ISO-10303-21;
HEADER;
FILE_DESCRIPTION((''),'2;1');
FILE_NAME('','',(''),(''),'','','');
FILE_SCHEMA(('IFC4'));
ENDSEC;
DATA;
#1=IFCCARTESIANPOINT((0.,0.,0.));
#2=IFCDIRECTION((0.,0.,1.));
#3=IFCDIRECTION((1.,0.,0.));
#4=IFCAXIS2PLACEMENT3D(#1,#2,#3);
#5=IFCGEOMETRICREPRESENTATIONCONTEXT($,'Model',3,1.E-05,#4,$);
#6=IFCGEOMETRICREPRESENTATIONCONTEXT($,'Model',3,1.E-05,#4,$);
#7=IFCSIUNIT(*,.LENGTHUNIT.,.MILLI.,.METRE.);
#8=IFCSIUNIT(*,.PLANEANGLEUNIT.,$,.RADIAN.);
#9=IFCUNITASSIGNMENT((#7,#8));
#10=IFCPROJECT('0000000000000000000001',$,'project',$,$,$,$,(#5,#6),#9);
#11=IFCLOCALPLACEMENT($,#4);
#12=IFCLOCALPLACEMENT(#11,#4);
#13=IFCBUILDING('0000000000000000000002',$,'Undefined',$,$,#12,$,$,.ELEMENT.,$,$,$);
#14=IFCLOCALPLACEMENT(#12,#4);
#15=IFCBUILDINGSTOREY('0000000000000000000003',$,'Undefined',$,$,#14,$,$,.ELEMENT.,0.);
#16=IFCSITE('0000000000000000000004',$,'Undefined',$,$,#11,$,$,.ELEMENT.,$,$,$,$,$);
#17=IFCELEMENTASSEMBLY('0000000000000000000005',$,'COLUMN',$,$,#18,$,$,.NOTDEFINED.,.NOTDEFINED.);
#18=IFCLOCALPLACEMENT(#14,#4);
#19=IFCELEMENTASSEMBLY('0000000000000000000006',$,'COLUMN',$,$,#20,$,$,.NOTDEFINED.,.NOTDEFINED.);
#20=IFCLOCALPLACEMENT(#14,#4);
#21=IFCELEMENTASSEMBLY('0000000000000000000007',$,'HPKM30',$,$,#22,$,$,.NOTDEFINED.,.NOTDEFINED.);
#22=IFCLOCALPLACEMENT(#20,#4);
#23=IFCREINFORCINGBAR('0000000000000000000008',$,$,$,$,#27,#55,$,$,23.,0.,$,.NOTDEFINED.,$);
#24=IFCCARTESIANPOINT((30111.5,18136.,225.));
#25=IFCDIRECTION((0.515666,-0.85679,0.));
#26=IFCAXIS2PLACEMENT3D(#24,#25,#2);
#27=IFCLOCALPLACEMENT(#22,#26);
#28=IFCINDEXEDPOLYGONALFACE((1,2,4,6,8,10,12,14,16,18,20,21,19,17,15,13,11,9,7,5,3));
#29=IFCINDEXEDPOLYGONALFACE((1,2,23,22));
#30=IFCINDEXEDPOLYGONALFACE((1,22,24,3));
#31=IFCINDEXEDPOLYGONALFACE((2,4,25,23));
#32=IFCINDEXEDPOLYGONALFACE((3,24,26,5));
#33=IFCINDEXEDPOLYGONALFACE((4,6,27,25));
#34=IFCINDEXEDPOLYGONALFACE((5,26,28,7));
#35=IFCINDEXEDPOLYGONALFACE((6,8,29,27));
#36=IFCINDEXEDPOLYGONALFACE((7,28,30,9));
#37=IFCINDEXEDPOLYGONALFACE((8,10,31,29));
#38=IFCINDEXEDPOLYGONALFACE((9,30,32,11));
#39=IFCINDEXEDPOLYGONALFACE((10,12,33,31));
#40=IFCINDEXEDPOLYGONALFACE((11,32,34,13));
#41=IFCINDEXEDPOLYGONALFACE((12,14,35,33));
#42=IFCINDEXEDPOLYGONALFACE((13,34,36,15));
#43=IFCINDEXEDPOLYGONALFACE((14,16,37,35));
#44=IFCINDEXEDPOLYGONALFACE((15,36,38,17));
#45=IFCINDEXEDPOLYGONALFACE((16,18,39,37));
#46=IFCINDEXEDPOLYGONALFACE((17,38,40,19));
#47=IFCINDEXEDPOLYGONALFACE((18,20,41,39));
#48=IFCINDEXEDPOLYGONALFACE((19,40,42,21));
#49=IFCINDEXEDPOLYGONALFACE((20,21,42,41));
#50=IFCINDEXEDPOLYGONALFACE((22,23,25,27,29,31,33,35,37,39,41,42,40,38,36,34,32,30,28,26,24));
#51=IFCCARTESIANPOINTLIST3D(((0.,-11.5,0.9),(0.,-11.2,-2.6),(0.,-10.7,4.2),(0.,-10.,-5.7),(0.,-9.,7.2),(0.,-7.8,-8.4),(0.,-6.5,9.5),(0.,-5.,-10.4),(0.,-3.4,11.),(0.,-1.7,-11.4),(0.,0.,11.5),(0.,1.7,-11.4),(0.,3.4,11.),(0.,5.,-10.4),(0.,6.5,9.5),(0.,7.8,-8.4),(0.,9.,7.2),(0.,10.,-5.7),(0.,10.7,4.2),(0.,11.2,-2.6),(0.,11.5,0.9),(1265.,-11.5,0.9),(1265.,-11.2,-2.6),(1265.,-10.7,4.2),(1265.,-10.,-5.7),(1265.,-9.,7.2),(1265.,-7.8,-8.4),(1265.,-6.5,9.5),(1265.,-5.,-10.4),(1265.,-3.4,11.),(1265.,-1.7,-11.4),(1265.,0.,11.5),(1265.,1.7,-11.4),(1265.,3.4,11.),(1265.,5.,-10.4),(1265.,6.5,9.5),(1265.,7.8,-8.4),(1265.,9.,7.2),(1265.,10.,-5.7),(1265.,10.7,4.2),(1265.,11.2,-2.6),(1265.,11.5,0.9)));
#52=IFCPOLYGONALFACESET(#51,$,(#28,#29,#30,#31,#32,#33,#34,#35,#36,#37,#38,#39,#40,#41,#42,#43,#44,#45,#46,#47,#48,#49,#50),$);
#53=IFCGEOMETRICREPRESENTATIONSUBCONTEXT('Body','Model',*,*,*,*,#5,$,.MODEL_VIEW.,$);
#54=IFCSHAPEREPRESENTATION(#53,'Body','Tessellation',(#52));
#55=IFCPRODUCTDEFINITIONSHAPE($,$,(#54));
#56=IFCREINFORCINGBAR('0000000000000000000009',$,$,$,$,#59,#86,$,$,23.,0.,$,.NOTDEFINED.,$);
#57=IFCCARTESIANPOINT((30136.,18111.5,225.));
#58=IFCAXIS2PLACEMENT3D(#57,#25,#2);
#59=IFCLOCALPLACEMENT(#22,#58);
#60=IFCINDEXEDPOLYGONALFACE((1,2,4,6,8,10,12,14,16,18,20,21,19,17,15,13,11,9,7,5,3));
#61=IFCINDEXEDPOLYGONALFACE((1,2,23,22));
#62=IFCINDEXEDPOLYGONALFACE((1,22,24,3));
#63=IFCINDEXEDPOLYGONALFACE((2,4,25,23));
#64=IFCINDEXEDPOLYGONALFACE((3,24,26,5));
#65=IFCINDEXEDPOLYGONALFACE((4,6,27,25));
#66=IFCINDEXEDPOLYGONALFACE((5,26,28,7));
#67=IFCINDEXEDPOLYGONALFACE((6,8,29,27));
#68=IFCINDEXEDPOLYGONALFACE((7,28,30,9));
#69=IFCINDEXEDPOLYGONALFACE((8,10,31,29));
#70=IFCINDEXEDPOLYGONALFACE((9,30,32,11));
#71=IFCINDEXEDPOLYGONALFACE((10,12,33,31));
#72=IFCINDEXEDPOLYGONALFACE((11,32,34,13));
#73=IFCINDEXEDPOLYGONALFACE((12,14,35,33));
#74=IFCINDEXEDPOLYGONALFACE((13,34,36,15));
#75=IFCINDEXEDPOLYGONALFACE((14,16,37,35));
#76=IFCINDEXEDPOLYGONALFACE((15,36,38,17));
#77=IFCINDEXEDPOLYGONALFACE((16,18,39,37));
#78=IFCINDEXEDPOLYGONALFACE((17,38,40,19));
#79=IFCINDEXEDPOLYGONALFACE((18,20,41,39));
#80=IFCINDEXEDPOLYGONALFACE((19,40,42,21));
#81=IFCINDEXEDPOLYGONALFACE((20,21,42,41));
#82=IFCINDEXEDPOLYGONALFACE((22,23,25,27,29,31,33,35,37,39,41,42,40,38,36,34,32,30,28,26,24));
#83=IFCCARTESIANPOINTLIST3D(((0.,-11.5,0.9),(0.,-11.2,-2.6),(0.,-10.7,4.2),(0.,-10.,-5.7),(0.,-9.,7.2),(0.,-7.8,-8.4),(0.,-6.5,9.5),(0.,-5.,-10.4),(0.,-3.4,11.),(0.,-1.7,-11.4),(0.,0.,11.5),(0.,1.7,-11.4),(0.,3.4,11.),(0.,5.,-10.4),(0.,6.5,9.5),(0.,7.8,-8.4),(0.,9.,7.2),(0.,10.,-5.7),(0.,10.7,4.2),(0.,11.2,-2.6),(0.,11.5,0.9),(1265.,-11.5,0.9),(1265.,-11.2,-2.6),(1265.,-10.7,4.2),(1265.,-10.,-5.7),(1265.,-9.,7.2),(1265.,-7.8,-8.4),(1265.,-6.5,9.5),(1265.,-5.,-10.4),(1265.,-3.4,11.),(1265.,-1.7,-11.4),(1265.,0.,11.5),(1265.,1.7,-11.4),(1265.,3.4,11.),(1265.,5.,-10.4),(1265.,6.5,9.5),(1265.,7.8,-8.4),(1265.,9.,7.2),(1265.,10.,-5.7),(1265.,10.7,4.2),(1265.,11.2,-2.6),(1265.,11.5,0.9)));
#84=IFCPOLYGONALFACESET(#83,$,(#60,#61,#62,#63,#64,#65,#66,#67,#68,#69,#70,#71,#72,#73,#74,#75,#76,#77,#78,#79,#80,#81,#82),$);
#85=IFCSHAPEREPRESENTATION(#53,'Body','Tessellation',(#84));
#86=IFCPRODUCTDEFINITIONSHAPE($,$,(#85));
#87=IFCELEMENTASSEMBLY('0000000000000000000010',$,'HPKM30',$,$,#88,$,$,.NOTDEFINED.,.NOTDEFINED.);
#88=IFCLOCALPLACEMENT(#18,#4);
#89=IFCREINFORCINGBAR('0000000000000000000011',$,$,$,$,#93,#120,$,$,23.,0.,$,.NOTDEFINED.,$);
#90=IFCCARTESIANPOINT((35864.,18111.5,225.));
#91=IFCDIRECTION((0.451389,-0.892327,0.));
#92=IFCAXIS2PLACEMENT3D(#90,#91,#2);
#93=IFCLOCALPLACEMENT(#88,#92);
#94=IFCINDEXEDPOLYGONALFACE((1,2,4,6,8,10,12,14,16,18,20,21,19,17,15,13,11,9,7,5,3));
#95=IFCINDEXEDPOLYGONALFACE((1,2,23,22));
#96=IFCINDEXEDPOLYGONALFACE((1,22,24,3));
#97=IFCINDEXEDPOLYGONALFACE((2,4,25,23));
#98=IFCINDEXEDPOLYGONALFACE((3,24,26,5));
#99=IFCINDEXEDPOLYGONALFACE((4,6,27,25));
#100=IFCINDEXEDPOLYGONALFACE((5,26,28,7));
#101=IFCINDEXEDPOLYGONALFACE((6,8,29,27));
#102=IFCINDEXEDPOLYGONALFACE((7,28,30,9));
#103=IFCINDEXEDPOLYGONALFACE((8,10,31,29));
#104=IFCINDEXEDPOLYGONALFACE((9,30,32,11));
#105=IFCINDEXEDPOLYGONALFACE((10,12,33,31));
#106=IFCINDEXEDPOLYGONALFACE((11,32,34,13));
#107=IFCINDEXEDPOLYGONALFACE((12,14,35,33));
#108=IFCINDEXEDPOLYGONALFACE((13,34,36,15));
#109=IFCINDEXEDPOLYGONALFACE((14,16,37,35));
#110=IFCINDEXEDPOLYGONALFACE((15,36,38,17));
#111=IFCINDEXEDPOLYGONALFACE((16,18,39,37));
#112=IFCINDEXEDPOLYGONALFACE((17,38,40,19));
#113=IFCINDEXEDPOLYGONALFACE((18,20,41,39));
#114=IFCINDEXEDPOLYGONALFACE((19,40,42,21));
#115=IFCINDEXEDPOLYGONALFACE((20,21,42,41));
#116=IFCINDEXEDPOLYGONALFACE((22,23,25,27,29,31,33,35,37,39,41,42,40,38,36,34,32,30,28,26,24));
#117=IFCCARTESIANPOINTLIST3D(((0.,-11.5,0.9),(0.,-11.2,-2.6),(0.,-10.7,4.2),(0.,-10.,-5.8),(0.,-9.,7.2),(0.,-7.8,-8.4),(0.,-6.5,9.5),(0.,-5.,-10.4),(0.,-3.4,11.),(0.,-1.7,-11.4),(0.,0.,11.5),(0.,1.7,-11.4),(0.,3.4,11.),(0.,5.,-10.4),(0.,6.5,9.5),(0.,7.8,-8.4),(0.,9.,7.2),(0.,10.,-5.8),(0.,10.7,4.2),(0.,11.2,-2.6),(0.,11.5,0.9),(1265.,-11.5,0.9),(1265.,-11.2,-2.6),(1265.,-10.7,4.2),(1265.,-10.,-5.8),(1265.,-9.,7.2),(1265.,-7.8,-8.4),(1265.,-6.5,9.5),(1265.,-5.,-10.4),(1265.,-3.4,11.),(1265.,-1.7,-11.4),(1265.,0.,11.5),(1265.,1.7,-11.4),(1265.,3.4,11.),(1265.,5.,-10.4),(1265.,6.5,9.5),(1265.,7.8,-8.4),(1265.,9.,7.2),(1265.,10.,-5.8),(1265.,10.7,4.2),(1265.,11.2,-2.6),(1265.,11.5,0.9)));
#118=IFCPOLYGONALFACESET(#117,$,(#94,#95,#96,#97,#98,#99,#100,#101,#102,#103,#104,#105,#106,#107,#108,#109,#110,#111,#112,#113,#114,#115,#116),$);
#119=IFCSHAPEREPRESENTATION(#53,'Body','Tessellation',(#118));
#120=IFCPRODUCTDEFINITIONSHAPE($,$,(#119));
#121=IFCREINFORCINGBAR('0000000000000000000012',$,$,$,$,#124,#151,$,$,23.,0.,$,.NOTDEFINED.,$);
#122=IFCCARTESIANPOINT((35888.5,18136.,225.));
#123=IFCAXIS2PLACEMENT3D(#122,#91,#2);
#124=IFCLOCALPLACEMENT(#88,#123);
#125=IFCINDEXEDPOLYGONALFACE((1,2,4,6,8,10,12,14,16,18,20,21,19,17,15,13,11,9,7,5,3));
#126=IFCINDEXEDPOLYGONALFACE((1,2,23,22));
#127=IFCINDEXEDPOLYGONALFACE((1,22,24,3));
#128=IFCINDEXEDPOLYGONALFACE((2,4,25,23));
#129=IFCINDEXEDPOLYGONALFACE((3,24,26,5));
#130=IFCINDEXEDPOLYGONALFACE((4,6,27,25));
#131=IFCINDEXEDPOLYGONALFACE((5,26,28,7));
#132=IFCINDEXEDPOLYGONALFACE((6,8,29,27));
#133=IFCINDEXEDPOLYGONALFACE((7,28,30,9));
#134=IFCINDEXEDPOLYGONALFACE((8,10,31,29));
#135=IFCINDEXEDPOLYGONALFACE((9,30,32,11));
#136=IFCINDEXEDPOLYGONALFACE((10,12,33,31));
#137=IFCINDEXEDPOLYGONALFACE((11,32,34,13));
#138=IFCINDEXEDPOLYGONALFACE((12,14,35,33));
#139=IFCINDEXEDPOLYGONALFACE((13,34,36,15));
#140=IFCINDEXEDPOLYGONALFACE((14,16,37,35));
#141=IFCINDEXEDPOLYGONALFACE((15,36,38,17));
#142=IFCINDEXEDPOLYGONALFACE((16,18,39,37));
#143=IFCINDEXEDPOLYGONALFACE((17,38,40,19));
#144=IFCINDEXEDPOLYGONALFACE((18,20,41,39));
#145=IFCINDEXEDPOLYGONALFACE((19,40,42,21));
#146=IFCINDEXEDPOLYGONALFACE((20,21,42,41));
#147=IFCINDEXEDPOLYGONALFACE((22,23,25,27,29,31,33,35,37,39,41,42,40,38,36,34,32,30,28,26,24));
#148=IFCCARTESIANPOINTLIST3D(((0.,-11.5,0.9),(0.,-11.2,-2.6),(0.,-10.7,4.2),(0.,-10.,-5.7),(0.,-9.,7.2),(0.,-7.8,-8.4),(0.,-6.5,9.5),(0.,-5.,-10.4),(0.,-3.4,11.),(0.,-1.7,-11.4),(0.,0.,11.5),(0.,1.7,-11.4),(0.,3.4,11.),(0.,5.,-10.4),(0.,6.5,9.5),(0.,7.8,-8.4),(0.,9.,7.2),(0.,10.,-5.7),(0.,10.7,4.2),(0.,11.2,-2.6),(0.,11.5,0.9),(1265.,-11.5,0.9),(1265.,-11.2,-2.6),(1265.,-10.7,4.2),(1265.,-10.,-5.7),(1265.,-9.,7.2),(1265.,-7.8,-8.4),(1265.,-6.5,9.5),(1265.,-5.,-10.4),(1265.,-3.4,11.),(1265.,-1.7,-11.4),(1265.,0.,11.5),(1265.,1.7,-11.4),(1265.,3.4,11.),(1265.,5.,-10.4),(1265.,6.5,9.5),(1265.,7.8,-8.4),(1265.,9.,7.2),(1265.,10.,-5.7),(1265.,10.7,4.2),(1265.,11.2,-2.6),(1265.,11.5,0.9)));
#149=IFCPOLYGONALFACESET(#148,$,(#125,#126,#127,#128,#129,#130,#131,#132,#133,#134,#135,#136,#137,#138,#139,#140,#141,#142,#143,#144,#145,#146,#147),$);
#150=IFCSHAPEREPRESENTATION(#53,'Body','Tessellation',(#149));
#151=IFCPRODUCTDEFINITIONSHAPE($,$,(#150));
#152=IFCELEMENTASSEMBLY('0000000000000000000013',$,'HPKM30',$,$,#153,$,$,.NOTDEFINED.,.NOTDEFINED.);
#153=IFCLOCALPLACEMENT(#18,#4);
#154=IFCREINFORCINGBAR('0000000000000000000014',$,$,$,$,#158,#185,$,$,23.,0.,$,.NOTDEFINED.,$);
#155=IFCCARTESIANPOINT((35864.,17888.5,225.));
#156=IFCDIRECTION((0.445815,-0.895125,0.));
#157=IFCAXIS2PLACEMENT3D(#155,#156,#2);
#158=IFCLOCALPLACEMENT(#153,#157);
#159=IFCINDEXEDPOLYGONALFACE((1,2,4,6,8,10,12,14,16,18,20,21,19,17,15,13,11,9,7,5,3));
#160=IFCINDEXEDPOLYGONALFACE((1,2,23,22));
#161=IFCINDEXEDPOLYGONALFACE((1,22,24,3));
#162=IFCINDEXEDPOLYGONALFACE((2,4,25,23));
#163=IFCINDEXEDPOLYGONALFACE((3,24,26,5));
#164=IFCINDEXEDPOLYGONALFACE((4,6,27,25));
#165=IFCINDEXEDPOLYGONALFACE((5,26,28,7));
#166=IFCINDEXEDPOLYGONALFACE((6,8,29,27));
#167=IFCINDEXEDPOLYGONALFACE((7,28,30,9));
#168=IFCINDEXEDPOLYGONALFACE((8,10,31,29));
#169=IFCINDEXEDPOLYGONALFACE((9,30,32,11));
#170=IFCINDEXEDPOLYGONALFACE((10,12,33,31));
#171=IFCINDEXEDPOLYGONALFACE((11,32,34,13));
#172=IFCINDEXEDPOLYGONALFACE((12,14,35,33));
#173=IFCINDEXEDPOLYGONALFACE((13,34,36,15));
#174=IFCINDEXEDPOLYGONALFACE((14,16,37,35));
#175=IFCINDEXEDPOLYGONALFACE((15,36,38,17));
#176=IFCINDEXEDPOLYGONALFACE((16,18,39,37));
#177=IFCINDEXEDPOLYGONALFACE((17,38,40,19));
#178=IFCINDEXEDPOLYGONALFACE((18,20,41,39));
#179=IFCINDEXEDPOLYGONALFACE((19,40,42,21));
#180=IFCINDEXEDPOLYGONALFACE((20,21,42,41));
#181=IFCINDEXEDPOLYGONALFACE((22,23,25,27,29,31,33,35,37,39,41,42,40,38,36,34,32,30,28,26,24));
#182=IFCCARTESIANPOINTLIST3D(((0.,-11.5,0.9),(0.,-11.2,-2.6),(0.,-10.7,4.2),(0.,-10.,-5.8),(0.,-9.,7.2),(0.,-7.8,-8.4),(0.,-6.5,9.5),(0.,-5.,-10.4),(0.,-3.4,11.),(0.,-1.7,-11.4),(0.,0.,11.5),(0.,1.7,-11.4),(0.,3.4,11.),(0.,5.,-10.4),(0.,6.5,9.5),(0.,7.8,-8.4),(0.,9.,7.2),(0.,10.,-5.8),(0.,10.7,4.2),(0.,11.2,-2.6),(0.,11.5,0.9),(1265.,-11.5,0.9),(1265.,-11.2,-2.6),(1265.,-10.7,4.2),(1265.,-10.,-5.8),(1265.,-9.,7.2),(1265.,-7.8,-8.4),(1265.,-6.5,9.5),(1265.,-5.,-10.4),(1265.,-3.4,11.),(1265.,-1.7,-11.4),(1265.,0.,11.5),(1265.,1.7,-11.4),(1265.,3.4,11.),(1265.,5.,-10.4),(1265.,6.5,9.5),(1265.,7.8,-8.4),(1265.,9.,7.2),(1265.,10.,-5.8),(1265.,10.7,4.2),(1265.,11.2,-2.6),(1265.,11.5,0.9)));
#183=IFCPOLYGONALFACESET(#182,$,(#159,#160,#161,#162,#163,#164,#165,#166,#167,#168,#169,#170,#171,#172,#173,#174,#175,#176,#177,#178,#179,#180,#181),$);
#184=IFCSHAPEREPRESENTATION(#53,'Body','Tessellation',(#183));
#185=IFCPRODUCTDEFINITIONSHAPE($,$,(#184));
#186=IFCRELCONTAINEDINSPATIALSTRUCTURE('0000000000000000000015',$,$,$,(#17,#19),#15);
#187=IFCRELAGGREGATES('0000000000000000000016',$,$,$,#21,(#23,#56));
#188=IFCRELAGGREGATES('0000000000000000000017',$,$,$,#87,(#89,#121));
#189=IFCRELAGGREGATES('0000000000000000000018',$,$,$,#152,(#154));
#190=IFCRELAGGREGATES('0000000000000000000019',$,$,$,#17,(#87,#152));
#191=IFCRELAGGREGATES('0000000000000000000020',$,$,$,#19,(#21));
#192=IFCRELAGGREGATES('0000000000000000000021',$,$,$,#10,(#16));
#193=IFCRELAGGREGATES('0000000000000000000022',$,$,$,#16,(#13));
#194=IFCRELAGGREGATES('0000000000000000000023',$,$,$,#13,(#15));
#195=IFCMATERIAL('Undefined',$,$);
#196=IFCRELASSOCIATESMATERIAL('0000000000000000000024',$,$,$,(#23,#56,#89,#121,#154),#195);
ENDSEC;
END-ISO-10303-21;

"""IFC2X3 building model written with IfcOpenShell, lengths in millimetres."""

from ifc_helpers import new_model, entity, si_unit, frame, origin_with_axes, place, context, subcontext, project, spatial, source, transform, mapped, material, element, aggregate, save


model = new_model("IFC2X3")

# Units and contexts
model_context_1 = context("Model", 3, precision=1e-05, world=origin_with_axes())
model_context_2 = context("Model", 3, precision=1e-05, world=origin_with_axes())
body_context = subcontext(model_context_1, "Body", "Model", "MODEL_VIEW")
ifc_project = project(units=[si_unit("LENGTHUNIT", "METRE", prefix="MILLI"), si_unit("PLANEANGLEUNIT", "RADIAN")], contexts=[model_context_1, model_context_2])

# Site, building, storey
site_placement = place(None, origin_with_axes())
site = spatial("IfcSite", under=ifc_project, at=site_placement, Name="Undefined", CompositionType="ELEMENT")
building_placement = place(site_placement, origin_with_axes())
building = spatial("IfcBuilding", under=site, at=building_placement, Name="Undefined", CompositionType="ELEMENT")
storey_placement = place(building_placement, origin_with_axes())
storey = spatial("IfcBuildingStorey", under=building, at=storey_placement, Name="Undefined", CompositionType="ELEMENT", Elevation=0.0)

# Element assembly
assembly_1_placement = place(storey_placement, origin_with_axes())
assembly_1 = element("IfcElementAssembly", 1, at=assembly_1_placement, inside=storey, Name="COLUMN", AssemblyPlace="NOTDEFINED", PredefinedType="NOTDEFINED")

# Shared definitions
ifc_material_1 = material(Name="Undefined")

# Element assembly
assembly_2_placement = place(storey_placement, origin_with_axes())
assembly_2 = element("IfcElementAssembly", 2, at=assembly_2_placement, inside=storey, Name="COLUMN", AssemblyPlace="NOTDEFINED", PredefinedType="NOTDEFINED")

# Element assemblies, reinforcing bars
assembly_3_placement = place(assembly_2_placement, origin_with_axes())
assembly_3 = element("IfcElementAssembly", 3, at=assembly_3_placement, Name="HPKM30", AssemblyPlace="NOTDEFINED", PredefinedType="NOTDEFINED")
shared_shape_1 = source(origin_with_axes(), body_context, "Body", "AdvancedSweptSolid", [
    entity("IfcSweptDiskSolid", entity("IfcTrimmedCurve", entity("IfcLine", entity("IfcCartesianPoint", [0.0, 0.0, 0.0]), entity("IfcVector", entity("IfcDirection", [1.0, 0.0, 0.0]), 1.0)), [entity("IfcParameterValue", 0.0)], [entity("IfcParameterValue", 1265.0)], True, "PARAMETER"), 11.5, None, 0.0, 1265.0),
])
reinforcing_bar_1_placement = place(assembly_3_placement, frame((30111.5, 18136.0, 225.0), z_axis=(0.515666, -0.85679, 0.0), x_axis=(0.0, 0.0, 1.0)))
reinforcing_bar_1 = element("IfcReinforcingBar", 4, at=reinforcing_bar_1_placement, material=ifc_material_1, BarRole="NOTDEFINED", CrossSectionArea=0.0, NominalDiameter=23.0, context=body_context, shape_type="MappedRepresentation", body=[
    mapped(shared_shape_1, transform((0.0, 0.0, 0.0))),
])
shared_shape_2 = source(origin_with_axes(), body_context, "Body", "AdvancedSweptSolid", [
    entity("IfcSweptDiskSolid", entity("IfcTrimmedCurve", entity("IfcLine", entity("IfcCartesianPoint", [0.0, 0.0, 0.0]), entity("IfcVector", entity("IfcDirection", [1.0, 0.0, 0.0]), 1.0)), [entity("IfcParameterValue", 0.0)], [entity("IfcParameterValue", 1265.0)], True, "PARAMETER"), 11.5, None, 0.0, 1265.0),
])
reinforcing_bar_2_placement = place(assembly_3_placement, frame((30136.0, 18111.5, 225.0), z_axis=(0.515666, -0.85679, 0.0), x_axis=(0.0, 0.0, 1.0)))
reinforcing_bar_2 = element("IfcReinforcingBar", 5, at=reinforcing_bar_2_placement, material=ifc_material_1, BarRole="NOTDEFINED", CrossSectionArea=0.0, NominalDiameter=23.0, context=body_context, shape_type="MappedRepresentation", body=[
    mapped(shared_shape_2, transform((0.0, 0.0, 0.0))),
])
aggregate(assembly_3, [reinforcing_bar_1, reinforcing_bar_2])
assembly_4_placement = place(assembly_1_placement, origin_with_axes())
assembly_4 = element("IfcElementAssembly", 6, at=assembly_4_placement, Name="HPKM30", AssemblyPlace="NOTDEFINED", PredefinedType="NOTDEFINED")
shared_shape_3 = source(origin_with_axes(), body_context, "Body", "AdvancedSweptSolid", [
    entity("IfcSweptDiskSolid", entity("IfcTrimmedCurve", entity("IfcLine", entity("IfcCartesianPoint", [0.0, 0.0, 0.0]), entity("IfcVector", entity("IfcDirection", [1.0, 0.0, 0.0]), 1.0)), [entity("IfcParameterValue", 0.0)], [entity("IfcParameterValue", 1265.0)], True, "PARAMETER"), 11.5, None, 0.0, 1265.0),
])
reinforcing_bar_3_placement = place(assembly_4_placement, frame((35864.0, 18111.5, 225.0), z_axis=(0.451389, -0.892327, 0.0), x_axis=(0.0, 0.0, 1.0)))
reinforcing_bar_3 = element("IfcReinforcingBar", 7, at=reinforcing_bar_3_placement, material=ifc_material_1, BarRole="NOTDEFINED", CrossSectionArea=0.0, NominalDiameter=23.0, context=body_context, shape_type="MappedRepresentation", body=[
    mapped(shared_shape_3, transform((0.0, 0.0, 0.0))),
])
shared_shape_4 = source(origin_with_axes(), body_context, "Body", "AdvancedSweptSolid", [
    entity("IfcSweptDiskSolid", entity("IfcTrimmedCurve", entity("IfcLine", entity("IfcCartesianPoint", [0.0, 0.0, 0.0]), entity("IfcVector", entity("IfcDirection", [1.0, 0.0, 0.0]), 1.0)), [entity("IfcParameterValue", 0.0)], [entity("IfcParameterValue", 1265.0)], True, "PARAMETER"), 11.5, None, 0.0, 1265.0),
])
reinforcing_bar_4_placement = place(assembly_4_placement, frame((35888.5, 18136.0, 225.0), z_axis=(0.451389, -0.892327, 0.0), x_axis=(0.0, 0.0, 1.0)))
reinforcing_bar_4 = element("IfcReinforcingBar", 8, at=reinforcing_bar_4_placement, material=ifc_material_1, BarRole="NOTDEFINED", CrossSectionArea=0.0, NominalDiameter=23.0, context=body_context, shape_type="MappedRepresentation", body=[
    mapped(shared_shape_4, transform((0.0, 0.0, 0.0))),
])
aggregate(assembly_4, [reinforcing_bar_3, reinforcing_bar_4])

# Element assembly, reinforcing bar
assembly_5_placement = place(assembly_1_placement, origin_with_axes())
assembly_5 = element("IfcElementAssembly", 9, at=assembly_5_placement, Name="HPKM30", AssemblyPlace="NOTDEFINED", PredefinedType="NOTDEFINED")
shared_shape_5 = source(origin_with_axes(), body_context, "Body", "AdvancedSweptSolid", [
    entity("IfcSweptDiskSolid", entity("IfcTrimmedCurve", entity("IfcLine", entity("IfcCartesianPoint", [0.0, 0.0, 0.0]), entity("IfcVector", entity("IfcDirection", [1.0, 0.0, 0.0]), 1.0)), [entity("IfcParameterValue", 0.0)], [entity("IfcParameterValue", 1265.0)], True, "PARAMETER"), 11.5, None, 0.0, 1265.0),
])
reinforcing_bar_5_placement = place(assembly_5_placement, frame((35864.0, 17888.5, 225.0), z_axis=(0.445815, -0.895125, 0.0), x_axis=(0.0, 0.0, 1.0)))
reinforcing_bar_5 = element("IfcReinforcingBar", 10, at=reinforcing_bar_5_placement, material=ifc_material_1, BarRole="NOTDEFINED", CrossSectionArea=0.0, NominalDiameter=23.0, context=body_context, shape_type="MappedRepresentation", body=[
    mapped(shared_shape_5, transform((0.0, 0.0, 0.0))),
])
aggregate(assembly_5, [reinforcing_bar_5])

aggregate(assembly_1, [assembly_4, assembly_5])
aggregate(assembly_2, [assembly_3])

save(model, "model.ifc")
